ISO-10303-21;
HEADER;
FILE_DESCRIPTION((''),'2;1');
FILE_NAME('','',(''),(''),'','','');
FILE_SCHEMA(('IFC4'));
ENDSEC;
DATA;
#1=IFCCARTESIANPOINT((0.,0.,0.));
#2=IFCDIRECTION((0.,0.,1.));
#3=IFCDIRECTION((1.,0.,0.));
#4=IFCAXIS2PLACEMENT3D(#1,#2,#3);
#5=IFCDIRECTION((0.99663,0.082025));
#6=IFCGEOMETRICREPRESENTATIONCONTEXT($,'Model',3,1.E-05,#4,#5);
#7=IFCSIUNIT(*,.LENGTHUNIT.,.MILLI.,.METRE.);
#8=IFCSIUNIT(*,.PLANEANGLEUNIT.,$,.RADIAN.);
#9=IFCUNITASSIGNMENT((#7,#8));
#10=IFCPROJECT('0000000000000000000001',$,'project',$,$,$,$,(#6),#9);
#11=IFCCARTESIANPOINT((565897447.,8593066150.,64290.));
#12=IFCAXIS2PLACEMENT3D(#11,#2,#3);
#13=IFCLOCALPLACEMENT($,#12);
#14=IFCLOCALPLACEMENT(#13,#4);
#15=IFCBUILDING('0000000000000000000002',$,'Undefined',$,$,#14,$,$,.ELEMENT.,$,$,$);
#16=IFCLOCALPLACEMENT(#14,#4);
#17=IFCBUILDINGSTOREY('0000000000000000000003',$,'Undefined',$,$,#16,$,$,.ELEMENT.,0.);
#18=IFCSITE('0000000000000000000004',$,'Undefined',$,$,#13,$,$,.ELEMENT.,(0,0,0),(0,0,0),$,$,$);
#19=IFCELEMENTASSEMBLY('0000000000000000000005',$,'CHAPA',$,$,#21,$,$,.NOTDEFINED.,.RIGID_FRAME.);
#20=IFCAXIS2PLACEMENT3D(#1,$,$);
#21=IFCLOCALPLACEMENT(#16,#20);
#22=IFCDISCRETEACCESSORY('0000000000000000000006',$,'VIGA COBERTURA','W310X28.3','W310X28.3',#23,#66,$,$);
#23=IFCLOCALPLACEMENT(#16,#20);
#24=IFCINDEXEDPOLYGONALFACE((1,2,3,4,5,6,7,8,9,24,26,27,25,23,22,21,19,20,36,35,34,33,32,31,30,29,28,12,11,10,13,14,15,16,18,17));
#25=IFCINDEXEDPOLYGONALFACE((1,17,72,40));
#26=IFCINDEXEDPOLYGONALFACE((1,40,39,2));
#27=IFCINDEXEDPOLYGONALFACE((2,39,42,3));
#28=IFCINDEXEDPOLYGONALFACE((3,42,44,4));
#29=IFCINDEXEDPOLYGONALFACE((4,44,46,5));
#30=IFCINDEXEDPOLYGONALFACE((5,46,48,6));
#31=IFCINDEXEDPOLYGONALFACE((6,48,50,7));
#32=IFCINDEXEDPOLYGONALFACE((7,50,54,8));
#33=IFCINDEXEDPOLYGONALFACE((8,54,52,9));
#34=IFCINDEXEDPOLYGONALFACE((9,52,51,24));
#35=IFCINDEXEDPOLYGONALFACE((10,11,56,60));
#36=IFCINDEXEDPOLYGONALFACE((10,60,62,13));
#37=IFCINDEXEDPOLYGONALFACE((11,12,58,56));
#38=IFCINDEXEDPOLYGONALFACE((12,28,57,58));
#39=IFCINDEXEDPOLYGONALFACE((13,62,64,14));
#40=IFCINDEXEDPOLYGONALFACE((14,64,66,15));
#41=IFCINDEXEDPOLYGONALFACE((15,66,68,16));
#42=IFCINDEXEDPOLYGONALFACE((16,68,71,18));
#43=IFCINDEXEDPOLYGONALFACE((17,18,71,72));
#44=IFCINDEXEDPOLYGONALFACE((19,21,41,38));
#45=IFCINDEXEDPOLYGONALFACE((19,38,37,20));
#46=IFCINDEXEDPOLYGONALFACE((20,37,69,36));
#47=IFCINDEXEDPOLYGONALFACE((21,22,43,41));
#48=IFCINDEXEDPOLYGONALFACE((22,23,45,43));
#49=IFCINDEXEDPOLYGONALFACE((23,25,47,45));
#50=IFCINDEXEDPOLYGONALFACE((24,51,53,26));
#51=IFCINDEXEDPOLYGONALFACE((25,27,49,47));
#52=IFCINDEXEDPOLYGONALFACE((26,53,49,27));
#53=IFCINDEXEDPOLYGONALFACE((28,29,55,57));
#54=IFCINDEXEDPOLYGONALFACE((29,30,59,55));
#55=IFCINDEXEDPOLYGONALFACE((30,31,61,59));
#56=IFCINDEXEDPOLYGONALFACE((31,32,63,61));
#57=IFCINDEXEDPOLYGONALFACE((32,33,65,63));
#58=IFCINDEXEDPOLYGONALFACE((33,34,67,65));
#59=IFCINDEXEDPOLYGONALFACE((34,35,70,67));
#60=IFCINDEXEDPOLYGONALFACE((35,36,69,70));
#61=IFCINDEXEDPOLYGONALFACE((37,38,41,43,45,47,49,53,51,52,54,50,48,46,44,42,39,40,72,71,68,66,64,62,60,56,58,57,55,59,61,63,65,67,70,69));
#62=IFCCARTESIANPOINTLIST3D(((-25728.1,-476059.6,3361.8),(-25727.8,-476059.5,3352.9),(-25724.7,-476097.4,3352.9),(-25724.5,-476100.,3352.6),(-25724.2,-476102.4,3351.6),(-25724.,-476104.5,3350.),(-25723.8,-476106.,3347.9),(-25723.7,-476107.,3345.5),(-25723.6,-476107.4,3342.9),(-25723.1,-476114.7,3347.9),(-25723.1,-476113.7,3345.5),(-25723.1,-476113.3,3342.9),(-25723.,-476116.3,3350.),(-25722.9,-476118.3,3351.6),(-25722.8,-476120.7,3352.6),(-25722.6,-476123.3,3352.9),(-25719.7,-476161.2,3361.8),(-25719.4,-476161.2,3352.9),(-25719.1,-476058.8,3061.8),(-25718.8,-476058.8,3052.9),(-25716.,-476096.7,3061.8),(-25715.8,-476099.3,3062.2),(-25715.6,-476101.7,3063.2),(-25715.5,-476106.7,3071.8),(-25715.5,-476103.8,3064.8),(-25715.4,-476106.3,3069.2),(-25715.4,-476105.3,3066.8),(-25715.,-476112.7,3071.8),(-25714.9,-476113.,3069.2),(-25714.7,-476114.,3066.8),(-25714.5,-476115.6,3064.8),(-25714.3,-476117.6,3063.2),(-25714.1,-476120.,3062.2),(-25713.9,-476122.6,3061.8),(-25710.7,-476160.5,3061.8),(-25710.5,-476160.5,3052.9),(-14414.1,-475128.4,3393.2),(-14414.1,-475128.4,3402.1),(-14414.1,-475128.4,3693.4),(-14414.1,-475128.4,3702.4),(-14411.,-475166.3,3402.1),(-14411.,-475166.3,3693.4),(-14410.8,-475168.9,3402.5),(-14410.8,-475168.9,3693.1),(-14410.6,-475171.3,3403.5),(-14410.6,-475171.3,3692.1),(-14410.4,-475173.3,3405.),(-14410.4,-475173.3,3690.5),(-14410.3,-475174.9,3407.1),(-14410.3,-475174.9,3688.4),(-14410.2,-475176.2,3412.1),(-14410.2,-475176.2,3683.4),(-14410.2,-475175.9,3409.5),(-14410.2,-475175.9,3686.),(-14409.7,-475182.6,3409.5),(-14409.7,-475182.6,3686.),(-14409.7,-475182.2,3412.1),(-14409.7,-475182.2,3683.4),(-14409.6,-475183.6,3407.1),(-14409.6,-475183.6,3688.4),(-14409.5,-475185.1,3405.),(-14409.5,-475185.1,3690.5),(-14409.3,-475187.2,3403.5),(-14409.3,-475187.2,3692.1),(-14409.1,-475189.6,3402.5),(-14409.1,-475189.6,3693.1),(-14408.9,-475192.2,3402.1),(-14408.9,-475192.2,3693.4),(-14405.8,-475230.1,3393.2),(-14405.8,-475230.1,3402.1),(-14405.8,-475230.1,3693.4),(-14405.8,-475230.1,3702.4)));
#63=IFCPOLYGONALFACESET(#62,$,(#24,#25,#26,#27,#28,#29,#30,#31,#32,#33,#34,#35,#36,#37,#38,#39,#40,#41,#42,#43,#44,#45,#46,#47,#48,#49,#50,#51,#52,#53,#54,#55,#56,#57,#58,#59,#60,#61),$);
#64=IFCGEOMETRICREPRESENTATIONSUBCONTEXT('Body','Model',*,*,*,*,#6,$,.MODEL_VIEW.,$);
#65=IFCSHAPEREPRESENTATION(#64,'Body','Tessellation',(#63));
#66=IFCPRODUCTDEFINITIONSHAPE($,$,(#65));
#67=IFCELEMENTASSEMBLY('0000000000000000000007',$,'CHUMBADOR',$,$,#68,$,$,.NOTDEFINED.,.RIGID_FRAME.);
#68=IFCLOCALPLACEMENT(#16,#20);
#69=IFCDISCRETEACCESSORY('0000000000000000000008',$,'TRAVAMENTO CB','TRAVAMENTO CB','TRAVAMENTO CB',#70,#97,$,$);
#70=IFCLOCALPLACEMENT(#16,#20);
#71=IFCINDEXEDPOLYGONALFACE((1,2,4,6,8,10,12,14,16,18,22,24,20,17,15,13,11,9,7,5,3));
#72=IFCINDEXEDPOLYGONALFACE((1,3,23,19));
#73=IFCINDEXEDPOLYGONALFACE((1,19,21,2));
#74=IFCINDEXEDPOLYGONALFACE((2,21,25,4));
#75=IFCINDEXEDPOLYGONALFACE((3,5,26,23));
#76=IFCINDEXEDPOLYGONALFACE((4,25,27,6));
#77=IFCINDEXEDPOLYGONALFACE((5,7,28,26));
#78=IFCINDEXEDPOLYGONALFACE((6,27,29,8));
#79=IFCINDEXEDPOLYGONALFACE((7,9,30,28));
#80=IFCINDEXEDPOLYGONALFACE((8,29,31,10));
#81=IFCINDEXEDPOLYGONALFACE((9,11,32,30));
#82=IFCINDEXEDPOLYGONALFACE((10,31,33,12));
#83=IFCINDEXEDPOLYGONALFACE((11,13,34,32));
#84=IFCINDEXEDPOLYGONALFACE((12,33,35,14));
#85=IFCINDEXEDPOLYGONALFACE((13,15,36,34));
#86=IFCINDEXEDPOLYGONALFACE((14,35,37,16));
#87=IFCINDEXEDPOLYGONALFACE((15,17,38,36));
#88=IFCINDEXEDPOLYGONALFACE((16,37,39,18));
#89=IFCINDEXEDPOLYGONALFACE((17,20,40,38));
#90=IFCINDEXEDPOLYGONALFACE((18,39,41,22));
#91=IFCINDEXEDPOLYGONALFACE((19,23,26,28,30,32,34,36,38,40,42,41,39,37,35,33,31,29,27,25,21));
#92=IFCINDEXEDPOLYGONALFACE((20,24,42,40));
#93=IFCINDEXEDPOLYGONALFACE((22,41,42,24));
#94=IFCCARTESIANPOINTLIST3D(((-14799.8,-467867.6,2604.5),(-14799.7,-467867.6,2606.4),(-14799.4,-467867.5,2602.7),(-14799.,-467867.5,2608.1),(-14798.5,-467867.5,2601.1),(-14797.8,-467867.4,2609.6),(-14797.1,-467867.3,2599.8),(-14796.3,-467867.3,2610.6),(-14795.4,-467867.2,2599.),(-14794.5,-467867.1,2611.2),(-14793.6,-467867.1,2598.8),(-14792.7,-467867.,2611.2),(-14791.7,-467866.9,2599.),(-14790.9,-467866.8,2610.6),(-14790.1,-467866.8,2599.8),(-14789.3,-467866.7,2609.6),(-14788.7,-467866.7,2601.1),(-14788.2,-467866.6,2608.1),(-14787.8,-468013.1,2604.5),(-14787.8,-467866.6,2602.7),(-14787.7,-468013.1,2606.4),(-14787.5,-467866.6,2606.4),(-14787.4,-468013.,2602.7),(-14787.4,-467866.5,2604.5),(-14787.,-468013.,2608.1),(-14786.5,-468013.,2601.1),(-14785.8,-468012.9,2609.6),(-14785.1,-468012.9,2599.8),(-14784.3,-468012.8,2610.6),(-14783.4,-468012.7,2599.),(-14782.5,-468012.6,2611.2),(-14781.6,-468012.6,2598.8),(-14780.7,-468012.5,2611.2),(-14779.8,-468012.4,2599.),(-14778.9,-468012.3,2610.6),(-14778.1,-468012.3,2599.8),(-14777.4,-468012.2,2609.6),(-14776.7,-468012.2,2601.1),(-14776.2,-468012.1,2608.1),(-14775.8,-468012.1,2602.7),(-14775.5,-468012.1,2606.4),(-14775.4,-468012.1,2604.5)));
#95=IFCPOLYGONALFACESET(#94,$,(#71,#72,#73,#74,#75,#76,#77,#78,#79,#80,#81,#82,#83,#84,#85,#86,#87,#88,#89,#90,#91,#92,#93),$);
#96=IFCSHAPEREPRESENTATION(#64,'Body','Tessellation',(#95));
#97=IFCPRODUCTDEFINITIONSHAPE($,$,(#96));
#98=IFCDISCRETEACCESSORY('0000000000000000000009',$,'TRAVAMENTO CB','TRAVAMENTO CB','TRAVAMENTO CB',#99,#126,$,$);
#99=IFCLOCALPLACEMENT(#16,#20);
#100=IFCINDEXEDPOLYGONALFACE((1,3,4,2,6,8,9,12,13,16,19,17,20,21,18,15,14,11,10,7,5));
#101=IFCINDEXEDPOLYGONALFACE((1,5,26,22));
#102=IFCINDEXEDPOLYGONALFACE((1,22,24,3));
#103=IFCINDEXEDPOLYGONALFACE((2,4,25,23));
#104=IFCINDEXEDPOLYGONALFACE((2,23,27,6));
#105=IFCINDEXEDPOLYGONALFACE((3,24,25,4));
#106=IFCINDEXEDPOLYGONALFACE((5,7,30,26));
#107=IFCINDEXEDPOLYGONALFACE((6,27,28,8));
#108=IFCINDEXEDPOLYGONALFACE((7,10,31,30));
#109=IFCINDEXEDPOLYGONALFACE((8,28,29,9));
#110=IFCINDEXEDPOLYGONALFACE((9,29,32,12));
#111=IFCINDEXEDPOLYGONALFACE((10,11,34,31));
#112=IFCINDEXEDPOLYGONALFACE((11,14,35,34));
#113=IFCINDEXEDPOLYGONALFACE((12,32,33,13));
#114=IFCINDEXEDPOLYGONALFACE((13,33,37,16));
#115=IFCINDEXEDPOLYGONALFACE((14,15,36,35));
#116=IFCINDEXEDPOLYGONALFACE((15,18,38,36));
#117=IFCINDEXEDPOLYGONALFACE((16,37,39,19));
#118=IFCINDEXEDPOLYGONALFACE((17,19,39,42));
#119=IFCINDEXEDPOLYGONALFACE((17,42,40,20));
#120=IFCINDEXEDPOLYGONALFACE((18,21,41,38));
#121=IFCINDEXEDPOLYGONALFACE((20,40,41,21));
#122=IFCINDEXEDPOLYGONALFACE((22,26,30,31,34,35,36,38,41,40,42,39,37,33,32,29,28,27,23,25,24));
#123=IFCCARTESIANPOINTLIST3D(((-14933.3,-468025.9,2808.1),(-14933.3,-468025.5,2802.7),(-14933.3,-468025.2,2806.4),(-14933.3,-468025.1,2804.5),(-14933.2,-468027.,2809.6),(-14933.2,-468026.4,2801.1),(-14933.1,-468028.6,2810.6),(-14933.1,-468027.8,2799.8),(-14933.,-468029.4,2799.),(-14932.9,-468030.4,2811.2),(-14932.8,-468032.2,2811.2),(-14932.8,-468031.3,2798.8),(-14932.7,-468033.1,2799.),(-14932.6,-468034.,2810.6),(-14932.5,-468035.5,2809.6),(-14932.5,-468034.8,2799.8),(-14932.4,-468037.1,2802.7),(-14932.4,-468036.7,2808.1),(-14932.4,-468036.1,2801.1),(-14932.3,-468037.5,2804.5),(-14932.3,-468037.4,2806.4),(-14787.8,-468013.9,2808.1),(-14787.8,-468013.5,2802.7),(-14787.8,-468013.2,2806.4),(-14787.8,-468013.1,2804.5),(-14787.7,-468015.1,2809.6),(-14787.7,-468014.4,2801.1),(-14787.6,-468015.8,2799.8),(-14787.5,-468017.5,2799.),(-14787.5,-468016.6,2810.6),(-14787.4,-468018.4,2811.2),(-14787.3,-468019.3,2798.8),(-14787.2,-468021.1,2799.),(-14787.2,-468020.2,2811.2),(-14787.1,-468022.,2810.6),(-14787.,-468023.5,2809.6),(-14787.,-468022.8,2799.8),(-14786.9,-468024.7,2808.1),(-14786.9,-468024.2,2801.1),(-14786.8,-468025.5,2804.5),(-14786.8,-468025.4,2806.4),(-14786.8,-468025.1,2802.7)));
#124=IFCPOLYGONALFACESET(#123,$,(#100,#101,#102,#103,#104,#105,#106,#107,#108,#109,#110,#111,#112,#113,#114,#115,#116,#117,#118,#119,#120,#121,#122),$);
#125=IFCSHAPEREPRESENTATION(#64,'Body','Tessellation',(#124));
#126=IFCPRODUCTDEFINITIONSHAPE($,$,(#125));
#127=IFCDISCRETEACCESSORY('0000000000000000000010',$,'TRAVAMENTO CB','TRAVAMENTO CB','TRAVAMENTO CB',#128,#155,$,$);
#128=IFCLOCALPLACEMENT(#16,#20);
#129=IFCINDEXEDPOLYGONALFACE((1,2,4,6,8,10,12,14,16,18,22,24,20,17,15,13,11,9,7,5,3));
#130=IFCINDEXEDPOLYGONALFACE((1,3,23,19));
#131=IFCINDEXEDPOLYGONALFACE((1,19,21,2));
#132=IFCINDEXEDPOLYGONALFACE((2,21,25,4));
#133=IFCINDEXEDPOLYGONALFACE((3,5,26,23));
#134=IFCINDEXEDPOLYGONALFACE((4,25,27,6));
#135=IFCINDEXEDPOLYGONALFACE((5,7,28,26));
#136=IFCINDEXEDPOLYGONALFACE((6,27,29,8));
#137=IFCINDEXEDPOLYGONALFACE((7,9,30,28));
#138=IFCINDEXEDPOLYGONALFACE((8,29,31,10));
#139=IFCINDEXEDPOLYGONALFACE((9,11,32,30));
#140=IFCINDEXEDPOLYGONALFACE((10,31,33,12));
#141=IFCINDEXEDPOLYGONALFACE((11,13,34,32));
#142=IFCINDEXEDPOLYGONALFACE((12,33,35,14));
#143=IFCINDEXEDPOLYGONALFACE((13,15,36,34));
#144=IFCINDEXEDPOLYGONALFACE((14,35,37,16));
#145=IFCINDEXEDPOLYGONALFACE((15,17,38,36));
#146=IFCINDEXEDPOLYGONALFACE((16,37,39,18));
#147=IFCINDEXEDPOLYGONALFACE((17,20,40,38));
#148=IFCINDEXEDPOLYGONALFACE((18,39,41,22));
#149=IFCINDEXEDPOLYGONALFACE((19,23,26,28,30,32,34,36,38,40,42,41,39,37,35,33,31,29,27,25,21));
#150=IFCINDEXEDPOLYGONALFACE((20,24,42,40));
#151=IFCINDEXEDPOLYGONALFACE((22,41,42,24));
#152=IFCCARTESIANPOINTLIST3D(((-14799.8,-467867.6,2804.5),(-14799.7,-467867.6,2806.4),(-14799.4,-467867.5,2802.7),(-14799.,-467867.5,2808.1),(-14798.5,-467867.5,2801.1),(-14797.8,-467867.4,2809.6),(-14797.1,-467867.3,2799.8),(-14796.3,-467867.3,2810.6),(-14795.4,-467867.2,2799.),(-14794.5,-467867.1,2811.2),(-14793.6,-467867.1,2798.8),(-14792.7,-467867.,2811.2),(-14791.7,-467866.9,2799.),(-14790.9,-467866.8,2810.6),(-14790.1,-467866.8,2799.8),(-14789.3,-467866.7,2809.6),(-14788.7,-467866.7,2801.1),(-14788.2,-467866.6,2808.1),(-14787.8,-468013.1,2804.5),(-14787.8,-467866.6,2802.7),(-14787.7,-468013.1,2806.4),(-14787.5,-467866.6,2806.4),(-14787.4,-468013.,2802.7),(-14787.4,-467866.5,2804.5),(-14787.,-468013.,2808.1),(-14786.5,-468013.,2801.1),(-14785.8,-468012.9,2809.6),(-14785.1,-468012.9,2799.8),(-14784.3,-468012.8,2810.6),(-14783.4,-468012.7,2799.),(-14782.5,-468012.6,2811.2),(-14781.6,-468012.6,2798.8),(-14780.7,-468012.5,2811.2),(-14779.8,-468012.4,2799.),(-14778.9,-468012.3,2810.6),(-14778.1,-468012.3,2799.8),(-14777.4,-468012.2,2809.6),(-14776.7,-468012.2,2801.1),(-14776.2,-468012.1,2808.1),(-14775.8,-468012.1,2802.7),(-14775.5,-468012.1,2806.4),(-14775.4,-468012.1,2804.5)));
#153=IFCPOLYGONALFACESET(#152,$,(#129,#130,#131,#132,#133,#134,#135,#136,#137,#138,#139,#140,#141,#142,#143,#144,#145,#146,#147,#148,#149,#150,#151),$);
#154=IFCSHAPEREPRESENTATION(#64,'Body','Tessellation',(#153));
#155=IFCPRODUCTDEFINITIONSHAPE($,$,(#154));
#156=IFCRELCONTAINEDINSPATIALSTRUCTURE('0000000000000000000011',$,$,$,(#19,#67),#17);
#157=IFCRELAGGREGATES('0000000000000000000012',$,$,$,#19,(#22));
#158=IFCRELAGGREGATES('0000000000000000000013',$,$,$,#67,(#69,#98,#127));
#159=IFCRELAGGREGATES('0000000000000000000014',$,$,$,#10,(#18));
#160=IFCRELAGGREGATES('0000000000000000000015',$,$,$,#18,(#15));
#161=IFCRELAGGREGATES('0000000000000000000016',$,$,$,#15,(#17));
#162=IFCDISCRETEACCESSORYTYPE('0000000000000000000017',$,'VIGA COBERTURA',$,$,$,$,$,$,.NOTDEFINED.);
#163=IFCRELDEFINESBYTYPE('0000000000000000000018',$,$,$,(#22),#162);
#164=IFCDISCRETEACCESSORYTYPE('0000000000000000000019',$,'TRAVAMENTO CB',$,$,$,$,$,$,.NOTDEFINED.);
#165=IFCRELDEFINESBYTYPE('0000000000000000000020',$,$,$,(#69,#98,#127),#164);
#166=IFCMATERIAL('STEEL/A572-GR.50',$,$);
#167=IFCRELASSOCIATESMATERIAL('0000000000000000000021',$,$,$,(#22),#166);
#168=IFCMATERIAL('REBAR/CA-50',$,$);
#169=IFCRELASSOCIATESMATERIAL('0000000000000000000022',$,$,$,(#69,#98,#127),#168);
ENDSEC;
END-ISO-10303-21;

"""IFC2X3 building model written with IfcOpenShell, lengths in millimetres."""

from ifc_helpers import new_model, si_unit, direction, frame, origin_with_axes, origin_2d_with_axis, place, context, subcontext, project, spatial, circle, i_section, extrude, clip, halfspace, material, type_object, element, aggregate, save


model = new_model("IFC2X3")

# Units and contexts
model_context = context("Model", 3, precision=1e-05, world=origin_with_axes(), true_north=direction((0.99663, 0.082025)))
body_context = subcontext(model_context, "Body", "Model", "MODEL_VIEW")
ifc_project = project(units=[si_unit("LENGTHUNIT", "METRE", prefix="MILLI"), si_unit("PLANEANGLEUNIT", "RADIAN")], contexts=[model_context])

# Site, building, storey
site_placement = place(None, frame((565897447.0, 8593066150.0, 64290.0), z_axis=(0.0, 0.0, 1.0), x_axis=(1.0, 0.0, 0.0)))
site = spatial("IfcSite", under=ifc_project, at=site_placement, Name="Undefined", CompositionType="ELEMENT", RefLatitude=(0, 0, 0), RefLongitude=(0, 0, 0))
building_placement = place(site_placement, origin_with_axes())
building = spatial("IfcBuilding", under=site, at=building_placement, Name="Undefined", CompositionType="ELEMENT")
storey_placement = place(building_placement, origin_with_axes())
storey = spatial("IfcBuildingStorey", under=building, at=storey_placement, Name="Undefined", CompositionType="ELEMENT", Elevation=0.0)

# Shared definitions
ifc_material_1 = material(Name="STEEL/A572-GR.50")

# Element assemblies, discrete accessories
assembly_1_placement = place(storey_placement, origin_with_axes())
assembly_1 = element("IfcElementAssembly", 1, at=assembly_1_placement, inside=storey, Name="CHAPA", AssemblyPlace="NOTDEFINED", PredefinedType="RIGID_FRAME")
discrete_accessory_type_1 = type_object("IfcDiscreteAccessoryType", Name="VIGA COBERTURA")
discrete_accessory_1_placement = place(assembly_1_placement, frame((-14392.7, -475177.8, 3548.3), z_axis=(0.029885, 0.00246, -0.99955), x_axis=(-0.996182, -0.081989, -0.029987)))
discrete_accessory_1 = element("IfcDiscreteAccessory", 2, at=discrete_accessory_1_placement, type_object=discrete_accessory_type_1, material=ifc_material_1, Name="VIGA COBERTURA", Description="W310X28.3", ObjectType="W310X28.3", context=body_context, shape_type="Clipping", body=[
    clip(extrude(i_section(OverallWidth=102.0, OverallDepth=309.0, WebThickness=6.0, FlangeThickness=8.9, FilletRadius=10.0, at=origin_2d_with_axis()), frame((11370.0, 0.0, 0.0), z_axis=(-1.0, 0.0, 0.0), x_axis=(0.0, -1.0, 0.0)), (0.0, 0.0, 1.0), 11370.0), halfspace(frame((12.7, -51.0, -154.5), z_axis=(-0.99955, 0.0, 0.029987), x_axis=(0.0, 1.0, 0.0)), False)),
])
aggregate(assembly_1, [discrete_accessory_1])
assembly_2_placement = place(storey_placement, origin_with_axes())
assembly_2 = element("IfcElementAssembly", 3, at=assembly_2_placement, inside=storey, Name="CHUMBADOR", AssemblyPlace="NOTDEFINED", PredefinedType="RIGID_FRAME")
ifc_material_2 = material(Name="REBAR/CA-50")
discrete_accessory_type_2 = type_object("IfcDiscreteAccessoryType", Name="TRAVAMENTO CB")
discrete_accessory_2_placement = place(assembly_2_placement, frame((-14781.6, -468012.6, 2605.0), z_axis=(0.99663, 0.082025, 0.0), x_axis=(-0.082025, 0.99663, 0.0)))
discrete_accessory_2 = element("IfcDiscreteAccessory", 4, at=discrete_accessory_2_placement, type_object=discrete_accessory_type_2, material=ifc_material_2, Name="TRAVAMENTO CB", Description="TRAVAMENTO CB", ObjectType="TRAVAMENTO CB", context=body_context, shape_type="SweptSolid", body=[
    extrude(circle(Radius=6.2, at=origin_2d_with_axis()), frame((146.0, 0.0, 0.0), z_axis=(-1.0, 0.0, 0.0), x_axis=(0.0, -1.0, 0.0)), (0.0, 0.0, 1.0), 146.0),
])
discrete_accessory_3_placement = place(assembly_2_placement, frame((-14932.8, -468031.3, 2805.0), z_axis=(0.082025, -0.99663, 0.0), x_axis=(0.99663, 0.082025, 0.0)))
discrete_accessory_3 = element("IfcDiscreteAccessory", 5, at=discrete_accessory_3_placement, type_object=discrete_accessory_type_2, material=ifc_material_2, Name="TRAVAMENTO CB", Description="TRAVAMENTO CB", ObjectType="TRAVAMENTO CB", context=body_context, shape_type="SweptSolid", body=[
    extrude(circle(Radius=6.2, at=origin_2d_with_axis()), frame((146.0, 0.0, 0.0), z_axis=(-1.0, 0.0, 0.0), x_axis=(0.0, -1.0, 0.0)), (0.0, 0.0, 1.0), 146.0),
])
discrete_accessory_4_placement = place(assembly_2_placement, frame((-14781.6, -468012.6, 2805.0), z_axis=(0.99663, 0.082025, 0.0), x_axis=(-0.082025, 0.99663, 0.0)))
discrete_accessory_4 = element("IfcDiscreteAccessory", 6, at=discrete_accessory_4_placement, type_object=discrete_accessory_type_2, material=ifc_material_2, Name="TRAVAMENTO CB", Description="TRAVAMENTO CB", ObjectType="TRAVAMENTO CB", context=body_context, shape_type="SweptSolid", body=[
    extrude(circle(Radius=6.2, at=origin_2d_with_axis()), frame((146.0, 0.0, 0.0), z_axis=(-1.0, 0.0, 0.0), x_axis=(0.0, -1.0, 0.0)), (0.0, 0.0, 1.0), 146.0),
])
aggregate(assembly_2, [discrete_accessory_2, discrete_accessory_3, discrete_accessory_4])

save(model, "model.ifc")
